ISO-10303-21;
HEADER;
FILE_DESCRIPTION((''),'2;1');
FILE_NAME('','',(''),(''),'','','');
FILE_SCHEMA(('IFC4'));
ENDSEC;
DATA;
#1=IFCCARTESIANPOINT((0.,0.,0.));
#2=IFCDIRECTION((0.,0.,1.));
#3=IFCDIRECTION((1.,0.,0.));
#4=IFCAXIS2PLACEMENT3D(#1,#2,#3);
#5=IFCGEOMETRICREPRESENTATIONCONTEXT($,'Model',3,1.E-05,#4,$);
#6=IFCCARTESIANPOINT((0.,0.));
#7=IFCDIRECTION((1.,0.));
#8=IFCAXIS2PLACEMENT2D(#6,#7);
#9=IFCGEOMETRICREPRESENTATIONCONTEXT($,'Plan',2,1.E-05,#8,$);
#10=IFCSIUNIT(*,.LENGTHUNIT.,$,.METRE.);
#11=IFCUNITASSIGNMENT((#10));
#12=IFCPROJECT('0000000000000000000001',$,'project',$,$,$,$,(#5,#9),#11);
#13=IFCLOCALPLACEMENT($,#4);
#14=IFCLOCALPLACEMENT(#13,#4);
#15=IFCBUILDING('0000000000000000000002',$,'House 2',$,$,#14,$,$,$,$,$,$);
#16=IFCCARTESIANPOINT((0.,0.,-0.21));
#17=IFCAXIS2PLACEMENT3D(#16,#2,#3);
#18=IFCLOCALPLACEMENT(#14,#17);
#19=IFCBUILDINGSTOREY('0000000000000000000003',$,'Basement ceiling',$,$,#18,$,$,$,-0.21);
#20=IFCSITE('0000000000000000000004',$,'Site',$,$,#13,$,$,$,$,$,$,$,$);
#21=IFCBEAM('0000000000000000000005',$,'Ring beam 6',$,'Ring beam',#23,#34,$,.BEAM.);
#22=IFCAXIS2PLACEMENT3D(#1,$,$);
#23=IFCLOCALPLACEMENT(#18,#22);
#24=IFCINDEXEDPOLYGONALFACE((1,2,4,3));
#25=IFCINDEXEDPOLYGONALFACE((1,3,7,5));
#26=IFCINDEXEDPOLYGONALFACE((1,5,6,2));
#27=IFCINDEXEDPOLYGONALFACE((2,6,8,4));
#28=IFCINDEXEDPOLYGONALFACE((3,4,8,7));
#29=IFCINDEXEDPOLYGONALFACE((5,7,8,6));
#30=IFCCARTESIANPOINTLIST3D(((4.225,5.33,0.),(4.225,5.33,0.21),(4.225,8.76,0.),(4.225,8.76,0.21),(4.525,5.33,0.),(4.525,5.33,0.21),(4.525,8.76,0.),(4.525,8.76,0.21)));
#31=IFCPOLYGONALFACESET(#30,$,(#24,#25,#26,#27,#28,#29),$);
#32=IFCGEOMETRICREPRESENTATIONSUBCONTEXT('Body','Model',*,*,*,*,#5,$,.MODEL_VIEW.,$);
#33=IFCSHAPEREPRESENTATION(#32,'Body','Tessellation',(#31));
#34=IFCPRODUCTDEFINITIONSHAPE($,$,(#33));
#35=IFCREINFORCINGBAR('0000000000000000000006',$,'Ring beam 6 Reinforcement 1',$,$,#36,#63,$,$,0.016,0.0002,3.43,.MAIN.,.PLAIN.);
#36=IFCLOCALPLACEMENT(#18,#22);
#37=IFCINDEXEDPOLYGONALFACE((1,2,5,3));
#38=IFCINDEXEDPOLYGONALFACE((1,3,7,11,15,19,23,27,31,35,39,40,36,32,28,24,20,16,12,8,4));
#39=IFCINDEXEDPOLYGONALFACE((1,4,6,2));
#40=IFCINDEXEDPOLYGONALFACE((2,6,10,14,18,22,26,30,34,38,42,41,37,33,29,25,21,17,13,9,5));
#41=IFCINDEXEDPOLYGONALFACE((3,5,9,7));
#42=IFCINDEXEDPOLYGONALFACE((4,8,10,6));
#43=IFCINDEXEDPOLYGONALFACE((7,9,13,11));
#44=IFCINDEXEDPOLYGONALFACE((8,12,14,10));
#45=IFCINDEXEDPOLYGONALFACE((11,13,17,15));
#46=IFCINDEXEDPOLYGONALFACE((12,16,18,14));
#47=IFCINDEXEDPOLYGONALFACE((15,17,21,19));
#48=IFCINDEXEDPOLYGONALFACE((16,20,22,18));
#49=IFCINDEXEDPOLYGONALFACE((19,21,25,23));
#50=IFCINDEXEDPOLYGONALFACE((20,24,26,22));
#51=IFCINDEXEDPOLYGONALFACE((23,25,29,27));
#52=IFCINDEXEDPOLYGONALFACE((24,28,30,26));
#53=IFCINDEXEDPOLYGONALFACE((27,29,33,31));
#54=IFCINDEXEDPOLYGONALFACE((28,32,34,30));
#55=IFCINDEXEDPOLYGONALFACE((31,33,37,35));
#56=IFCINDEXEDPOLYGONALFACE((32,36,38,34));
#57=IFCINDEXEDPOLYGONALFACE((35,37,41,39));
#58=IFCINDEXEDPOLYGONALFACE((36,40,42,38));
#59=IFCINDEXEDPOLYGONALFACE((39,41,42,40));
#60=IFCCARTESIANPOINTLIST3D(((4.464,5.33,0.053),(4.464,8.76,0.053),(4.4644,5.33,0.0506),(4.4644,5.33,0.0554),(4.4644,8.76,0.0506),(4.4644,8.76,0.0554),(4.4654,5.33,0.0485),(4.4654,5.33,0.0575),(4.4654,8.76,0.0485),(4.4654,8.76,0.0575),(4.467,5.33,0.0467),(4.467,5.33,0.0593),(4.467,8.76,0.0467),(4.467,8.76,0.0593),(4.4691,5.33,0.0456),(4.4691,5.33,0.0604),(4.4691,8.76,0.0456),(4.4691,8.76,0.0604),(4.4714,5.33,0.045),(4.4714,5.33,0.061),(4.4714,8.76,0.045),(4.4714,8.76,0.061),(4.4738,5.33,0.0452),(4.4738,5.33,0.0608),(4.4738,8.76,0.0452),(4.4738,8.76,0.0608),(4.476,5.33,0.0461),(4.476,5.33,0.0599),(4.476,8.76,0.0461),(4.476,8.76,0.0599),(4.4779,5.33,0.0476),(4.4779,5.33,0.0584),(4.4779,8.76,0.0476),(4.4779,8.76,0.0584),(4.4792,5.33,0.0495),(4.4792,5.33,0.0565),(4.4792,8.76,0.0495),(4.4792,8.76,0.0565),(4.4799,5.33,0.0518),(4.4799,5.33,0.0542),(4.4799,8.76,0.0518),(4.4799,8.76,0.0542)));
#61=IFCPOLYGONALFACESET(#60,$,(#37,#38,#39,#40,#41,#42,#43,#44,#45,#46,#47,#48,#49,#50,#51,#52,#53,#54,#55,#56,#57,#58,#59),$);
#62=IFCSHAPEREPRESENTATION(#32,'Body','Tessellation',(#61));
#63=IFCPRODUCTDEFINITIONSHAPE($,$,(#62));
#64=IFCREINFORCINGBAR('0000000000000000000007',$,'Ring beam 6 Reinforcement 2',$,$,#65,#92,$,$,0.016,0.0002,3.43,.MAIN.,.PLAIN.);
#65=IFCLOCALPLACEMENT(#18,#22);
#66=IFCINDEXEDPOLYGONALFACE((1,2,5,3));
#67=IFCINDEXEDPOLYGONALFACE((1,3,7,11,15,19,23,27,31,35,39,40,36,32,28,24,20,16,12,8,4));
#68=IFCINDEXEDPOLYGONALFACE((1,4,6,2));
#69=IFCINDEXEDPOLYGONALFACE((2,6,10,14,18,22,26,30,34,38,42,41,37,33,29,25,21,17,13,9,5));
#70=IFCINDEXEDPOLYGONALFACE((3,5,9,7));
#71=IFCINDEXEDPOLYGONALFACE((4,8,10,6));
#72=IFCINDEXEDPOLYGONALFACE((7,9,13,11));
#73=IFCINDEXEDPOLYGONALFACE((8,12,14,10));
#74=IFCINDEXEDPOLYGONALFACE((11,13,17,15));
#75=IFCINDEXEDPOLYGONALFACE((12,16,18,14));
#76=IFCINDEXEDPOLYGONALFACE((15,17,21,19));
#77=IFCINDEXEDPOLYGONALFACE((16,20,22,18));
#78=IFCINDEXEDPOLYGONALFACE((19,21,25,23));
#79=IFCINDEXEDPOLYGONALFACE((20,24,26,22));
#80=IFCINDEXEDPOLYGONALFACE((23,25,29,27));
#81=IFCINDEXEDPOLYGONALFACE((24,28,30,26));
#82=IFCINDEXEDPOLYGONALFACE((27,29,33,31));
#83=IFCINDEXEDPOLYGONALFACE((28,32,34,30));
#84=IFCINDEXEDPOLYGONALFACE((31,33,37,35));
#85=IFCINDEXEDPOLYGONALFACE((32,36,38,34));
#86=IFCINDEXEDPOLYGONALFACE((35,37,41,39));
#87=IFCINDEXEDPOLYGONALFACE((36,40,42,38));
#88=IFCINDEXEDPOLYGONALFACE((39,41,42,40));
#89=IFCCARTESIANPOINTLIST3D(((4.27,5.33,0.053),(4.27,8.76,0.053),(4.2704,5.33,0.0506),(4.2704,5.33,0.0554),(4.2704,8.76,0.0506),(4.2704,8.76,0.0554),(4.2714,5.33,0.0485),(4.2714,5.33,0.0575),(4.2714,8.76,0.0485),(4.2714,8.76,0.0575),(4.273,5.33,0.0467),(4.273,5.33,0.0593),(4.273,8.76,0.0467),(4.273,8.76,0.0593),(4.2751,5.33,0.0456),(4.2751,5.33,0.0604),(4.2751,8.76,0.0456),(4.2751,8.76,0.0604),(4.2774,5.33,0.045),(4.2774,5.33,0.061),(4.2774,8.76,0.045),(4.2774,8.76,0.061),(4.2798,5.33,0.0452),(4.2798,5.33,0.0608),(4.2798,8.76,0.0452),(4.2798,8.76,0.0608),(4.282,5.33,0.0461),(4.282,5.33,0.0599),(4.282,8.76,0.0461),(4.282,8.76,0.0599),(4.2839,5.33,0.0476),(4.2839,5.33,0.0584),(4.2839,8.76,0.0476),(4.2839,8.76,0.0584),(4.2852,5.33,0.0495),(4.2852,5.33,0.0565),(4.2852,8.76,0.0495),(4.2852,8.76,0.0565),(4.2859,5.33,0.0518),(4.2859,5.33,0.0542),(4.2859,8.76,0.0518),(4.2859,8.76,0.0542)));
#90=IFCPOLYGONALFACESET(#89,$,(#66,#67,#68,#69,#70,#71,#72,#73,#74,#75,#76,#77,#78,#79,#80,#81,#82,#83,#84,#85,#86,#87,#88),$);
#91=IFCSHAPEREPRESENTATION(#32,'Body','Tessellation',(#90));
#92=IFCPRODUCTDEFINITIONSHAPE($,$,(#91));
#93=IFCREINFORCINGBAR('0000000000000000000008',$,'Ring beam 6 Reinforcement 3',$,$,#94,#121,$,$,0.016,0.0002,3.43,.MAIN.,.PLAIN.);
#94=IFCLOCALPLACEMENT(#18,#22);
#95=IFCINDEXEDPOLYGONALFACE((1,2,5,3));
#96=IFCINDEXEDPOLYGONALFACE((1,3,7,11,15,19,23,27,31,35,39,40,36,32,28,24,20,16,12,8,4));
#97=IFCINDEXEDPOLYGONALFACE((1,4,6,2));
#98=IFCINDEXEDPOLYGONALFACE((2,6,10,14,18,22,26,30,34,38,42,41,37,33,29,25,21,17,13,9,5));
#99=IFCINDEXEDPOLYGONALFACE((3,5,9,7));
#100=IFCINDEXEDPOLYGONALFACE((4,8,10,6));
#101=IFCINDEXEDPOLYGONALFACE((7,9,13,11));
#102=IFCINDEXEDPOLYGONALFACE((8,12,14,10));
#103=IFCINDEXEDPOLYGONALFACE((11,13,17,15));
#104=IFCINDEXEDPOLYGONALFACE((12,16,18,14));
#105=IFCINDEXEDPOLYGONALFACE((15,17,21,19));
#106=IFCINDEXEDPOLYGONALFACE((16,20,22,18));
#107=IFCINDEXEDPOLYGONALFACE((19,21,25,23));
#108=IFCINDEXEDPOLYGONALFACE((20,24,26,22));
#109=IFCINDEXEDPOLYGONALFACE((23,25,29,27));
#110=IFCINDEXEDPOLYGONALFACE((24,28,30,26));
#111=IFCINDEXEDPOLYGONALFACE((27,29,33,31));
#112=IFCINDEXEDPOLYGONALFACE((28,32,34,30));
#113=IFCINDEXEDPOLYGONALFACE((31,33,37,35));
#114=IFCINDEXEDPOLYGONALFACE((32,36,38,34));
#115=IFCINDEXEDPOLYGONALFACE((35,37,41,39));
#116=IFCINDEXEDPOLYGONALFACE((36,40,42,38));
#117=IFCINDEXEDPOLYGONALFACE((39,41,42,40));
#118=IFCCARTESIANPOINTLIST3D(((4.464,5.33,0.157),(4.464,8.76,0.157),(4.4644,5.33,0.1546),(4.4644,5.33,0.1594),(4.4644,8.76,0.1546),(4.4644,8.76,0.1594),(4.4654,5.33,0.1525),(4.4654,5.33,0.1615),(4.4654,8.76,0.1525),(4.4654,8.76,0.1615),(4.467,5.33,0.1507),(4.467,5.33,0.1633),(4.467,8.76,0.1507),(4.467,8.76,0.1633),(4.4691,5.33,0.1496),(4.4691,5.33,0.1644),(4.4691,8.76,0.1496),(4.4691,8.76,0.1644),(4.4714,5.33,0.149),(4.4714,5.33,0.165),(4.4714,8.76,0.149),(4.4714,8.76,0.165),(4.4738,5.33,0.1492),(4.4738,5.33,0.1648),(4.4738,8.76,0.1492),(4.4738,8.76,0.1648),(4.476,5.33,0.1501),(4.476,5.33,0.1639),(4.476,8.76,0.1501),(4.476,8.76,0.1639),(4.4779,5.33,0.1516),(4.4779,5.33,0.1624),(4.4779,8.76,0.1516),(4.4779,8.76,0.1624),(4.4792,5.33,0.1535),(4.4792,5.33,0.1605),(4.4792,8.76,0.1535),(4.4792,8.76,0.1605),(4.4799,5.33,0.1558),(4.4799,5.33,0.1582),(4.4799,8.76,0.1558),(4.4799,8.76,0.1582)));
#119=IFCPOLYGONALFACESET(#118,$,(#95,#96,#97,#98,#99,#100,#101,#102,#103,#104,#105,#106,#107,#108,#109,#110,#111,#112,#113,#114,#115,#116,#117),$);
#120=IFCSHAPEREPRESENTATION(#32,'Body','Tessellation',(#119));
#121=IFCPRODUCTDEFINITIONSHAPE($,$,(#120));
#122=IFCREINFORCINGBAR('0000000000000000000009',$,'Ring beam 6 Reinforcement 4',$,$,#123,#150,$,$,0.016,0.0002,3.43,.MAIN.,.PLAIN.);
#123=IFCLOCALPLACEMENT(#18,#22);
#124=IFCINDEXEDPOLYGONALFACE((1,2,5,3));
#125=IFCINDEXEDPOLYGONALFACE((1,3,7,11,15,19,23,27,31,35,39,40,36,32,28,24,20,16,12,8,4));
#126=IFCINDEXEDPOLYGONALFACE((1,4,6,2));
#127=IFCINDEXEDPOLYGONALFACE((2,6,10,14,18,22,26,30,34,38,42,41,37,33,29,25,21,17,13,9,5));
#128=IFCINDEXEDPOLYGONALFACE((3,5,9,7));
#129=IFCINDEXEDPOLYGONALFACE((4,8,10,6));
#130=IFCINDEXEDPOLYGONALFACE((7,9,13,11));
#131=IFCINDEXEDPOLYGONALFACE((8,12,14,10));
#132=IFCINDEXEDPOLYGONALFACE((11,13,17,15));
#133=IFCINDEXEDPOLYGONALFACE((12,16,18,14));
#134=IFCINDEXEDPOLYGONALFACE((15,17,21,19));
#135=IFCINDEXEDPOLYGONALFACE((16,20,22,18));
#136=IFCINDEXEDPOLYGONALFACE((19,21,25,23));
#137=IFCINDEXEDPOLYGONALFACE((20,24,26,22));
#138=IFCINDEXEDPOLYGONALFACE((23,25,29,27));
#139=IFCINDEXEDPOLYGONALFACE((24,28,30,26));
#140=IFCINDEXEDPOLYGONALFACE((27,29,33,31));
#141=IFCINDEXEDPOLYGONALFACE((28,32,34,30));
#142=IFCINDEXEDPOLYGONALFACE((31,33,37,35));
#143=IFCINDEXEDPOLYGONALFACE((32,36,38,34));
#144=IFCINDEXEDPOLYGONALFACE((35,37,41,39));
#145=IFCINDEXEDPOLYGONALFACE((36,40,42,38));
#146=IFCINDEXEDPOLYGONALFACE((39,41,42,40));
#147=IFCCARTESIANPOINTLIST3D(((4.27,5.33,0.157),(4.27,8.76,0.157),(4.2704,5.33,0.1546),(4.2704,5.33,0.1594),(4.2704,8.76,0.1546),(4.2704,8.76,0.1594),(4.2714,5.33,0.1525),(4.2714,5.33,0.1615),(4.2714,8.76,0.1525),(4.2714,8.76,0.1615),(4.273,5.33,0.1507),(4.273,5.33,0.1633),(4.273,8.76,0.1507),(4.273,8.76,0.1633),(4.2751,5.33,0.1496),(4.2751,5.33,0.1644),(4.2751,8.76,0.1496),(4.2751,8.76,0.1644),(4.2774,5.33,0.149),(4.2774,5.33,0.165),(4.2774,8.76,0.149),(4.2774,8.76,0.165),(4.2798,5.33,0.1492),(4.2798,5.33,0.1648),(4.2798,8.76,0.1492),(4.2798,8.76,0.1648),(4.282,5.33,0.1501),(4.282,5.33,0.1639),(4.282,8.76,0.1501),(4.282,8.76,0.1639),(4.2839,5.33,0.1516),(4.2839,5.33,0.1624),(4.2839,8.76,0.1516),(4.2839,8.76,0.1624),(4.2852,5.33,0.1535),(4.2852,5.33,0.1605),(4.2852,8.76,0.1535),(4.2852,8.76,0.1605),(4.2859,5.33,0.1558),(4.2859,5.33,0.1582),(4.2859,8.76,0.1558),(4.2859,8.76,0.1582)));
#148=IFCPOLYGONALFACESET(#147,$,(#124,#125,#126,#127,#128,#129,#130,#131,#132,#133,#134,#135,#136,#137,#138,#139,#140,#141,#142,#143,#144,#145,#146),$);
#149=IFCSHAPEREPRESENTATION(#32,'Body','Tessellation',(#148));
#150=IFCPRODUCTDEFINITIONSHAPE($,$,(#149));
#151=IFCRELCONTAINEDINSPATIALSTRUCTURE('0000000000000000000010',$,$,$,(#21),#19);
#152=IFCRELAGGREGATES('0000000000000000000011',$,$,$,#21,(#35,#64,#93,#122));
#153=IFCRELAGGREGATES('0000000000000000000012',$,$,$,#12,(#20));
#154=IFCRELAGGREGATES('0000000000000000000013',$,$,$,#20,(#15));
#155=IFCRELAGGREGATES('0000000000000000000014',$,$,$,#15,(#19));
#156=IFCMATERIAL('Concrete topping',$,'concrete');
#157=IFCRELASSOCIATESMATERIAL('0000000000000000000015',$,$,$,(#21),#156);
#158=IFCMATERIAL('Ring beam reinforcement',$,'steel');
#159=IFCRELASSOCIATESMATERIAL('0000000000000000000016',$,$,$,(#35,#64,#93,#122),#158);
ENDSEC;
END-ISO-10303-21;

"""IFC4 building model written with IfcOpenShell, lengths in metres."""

from ifc_helpers import new_model, si_unit, frame, origin_with_axes, origin_2d, origin_2d_with_axis, place, context, subcontext, project, spatial, circle_curve, rectangle, outline, extrude, material, element, aggregate, save


model = new_model("IFC4")

# Units and contexts
model_context = context("Model", 3, precision=1e-05, world=origin_with_axes())
plan_context = context("Plan", 2, precision=1e-05, world=origin_2d_with_axis())
body_context = subcontext(model_context, "Body", "Model", "MODEL_VIEW")
ifc_project = project(units=[si_unit("LENGTHUNIT", "METRE")], contexts=[model_context, plan_context])

# Site, building, storey
site_placement = place(None, origin_with_axes())
site = spatial("IfcSite", under=ifc_project, at=site_placement, Name="Site")
building_placement = place(site_placement, origin_with_axes())
building = spatial("IfcBuilding", under=site, at=building_placement, Name="House 2")
storey_placement = place(building_placement, frame((0.0, 0.0, -0.21), z_axis=(0.0, 0.0, 1.0), x_axis=(1.0, 0.0, 0.0)))
storey = spatial("IfcBuildingStorey", under=building, at=storey_placement, Name="Basement ceiling", Elevation=-0.21)

# Beam
ifc_material_1 = material(Name="Concrete topping", Category="concrete")
beam_1_placement = place(storey_placement, frame((4.375, 5.33, 0.105), z_axis=(0.0, 0.0, 1.0), x_axis=(0.0, 1.0, 0.0)))
beam_1 = element("IfcBeam", 1, at=beam_1_placement, inside=storey, material=ifc_material_1, Name="Ring beam 6", ObjectType="Ring beam", PredefinedType="BEAM", context=body_context, shape_type="SweptSolid", body=[
    extrude(rectangle(XDim=0.3, YDim=0.21), frame((0.0, 0.0, 0.0), z_axis=(1.0, 0.0, 0.0), x_axis=(0.0, 1.0, 0.0)), (0.0, 0.0, 1.0), 3.43),
])

# Reinforcing bars
ifc_material_2 = material(Name="Ring beam reinforcement", Category="steel")
reinforcing_bar_1_placement = place(beam_1_placement, frame((0.0, -0.097, -0.052), z_axis=(0.0, 0.0, 1.0), x_axis=(1.0, 0.0, 0.0)))
reinforcing_bar_1 = element("IfcReinforcingBar", 2, at=reinforcing_bar_1_placement, material=ifc_material_2, Name="Ring beam 6 Reinforcement 1", BarLength=3.43, BarSurface="PLAIN", CrossSectionArea=0.0002, NominalDiameter=0.016, PredefinedType="MAIN", context=body_context, shape_type="SweptSolid", body=[
    extrude(outline(circle_curve(origin_2d(), 0.008)), frame((0.0, 0.0, 0.0), z_axis=(1.0, 0.0, 0.0), x_axis=(0.0, 1.0, 0.0)), (0.0, 0.0, 1.0), 3.43),
])
reinforcing_bar_2_placement = place(beam_1_placement, frame((0.0, 0.097, -0.052), z_axis=(0.0, 0.0, 1.0), x_axis=(1.0, 0.0, 0.0)))
reinforcing_bar_2 = element("IfcReinforcingBar", 3, at=reinforcing_bar_2_placement, material=ifc_material_2, Name="Ring beam 6 Reinforcement 2", BarLength=3.43, BarSurface="PLAIN", CrossSectionArea=0.0002, NominalDiameter=0.016, PredefinedType="MAIN", context=body_context, shape_type="SweptSolid", body=[
    extrude(outline(circle_curve(origin_2d(), 0.008)), frame((0.0, 0.0, 0.0), z_axis=(1.0, 0.0, 0.0), x_axis=(0.0, 1.0, 0.0)), (0.0, 0.0, 1.0), 3.43),
])
reinforcing_bar_3_placement = place(beam_1_placement, frame((0.0, -0.097, 0.052), z_axis=(0.0, 0.0, 1.0), x_axis=(1.0, 0.0, 0.0)))
reinforcing_bar_3 = element("IfcReinforcingBar", 4, at=reinforcing_bar_3_placement, material=ifc_material_2, Name="Ring beam 6 Reinforcement 3", BarLength=3.43, BarSurface="PLAIN", CrossSectionArea=0.0002, NominalDiameter=0.016, PredefinedType="MAIN", context=body_context, shape_type="SweptSolid", body=[
    extrude(outline(circle_curve(origin_2d(), 0.008)), frame((0.0, 0.0, 0.0), z_axis=(1.0, 0.0, 0.0), x_axis=(0.0, 1.0, 0.0)), (0.0, 0.0, 1.0), 3.43),
])
reinforcing_bar_4_placement = place(beam_1_placement, frame((0.0, 0.097, 0.052), z_axis=(0.0, 0.0, 1.0), x_axis=(1.0, 0.0, 0.0)))
reinforcing_bar_4 = element("IfcReinforcingBar", 5, at=reinforcing_bar_4_placement, material=ifc_material_2, Name="Ring beam 6 Reinforcement 4", BarLength=3.43, BarSurface="PLAIN", CrossSectionArea=0.0002, NominalDiameter=0.016, PredefinedType="MAIN", context=body_context, shape_type="SweptSolid", body=[
    extrude(outline(circle_curve(origin_2d(), 0.008)), frame((0.0, 0.0, 0.0), z_axis=(1.0, 0.0, 0.0), x_axis=(0.0, 1.0, 0.0)), (0.0, 0.0, 1.0), 3.43),
])
aggregate(beam_1, [reinforcing_bar_1, reinforcing_bar_2, reinforcing_bar_3, reinforcing_bar_4])

save(model, "model.ifc")
